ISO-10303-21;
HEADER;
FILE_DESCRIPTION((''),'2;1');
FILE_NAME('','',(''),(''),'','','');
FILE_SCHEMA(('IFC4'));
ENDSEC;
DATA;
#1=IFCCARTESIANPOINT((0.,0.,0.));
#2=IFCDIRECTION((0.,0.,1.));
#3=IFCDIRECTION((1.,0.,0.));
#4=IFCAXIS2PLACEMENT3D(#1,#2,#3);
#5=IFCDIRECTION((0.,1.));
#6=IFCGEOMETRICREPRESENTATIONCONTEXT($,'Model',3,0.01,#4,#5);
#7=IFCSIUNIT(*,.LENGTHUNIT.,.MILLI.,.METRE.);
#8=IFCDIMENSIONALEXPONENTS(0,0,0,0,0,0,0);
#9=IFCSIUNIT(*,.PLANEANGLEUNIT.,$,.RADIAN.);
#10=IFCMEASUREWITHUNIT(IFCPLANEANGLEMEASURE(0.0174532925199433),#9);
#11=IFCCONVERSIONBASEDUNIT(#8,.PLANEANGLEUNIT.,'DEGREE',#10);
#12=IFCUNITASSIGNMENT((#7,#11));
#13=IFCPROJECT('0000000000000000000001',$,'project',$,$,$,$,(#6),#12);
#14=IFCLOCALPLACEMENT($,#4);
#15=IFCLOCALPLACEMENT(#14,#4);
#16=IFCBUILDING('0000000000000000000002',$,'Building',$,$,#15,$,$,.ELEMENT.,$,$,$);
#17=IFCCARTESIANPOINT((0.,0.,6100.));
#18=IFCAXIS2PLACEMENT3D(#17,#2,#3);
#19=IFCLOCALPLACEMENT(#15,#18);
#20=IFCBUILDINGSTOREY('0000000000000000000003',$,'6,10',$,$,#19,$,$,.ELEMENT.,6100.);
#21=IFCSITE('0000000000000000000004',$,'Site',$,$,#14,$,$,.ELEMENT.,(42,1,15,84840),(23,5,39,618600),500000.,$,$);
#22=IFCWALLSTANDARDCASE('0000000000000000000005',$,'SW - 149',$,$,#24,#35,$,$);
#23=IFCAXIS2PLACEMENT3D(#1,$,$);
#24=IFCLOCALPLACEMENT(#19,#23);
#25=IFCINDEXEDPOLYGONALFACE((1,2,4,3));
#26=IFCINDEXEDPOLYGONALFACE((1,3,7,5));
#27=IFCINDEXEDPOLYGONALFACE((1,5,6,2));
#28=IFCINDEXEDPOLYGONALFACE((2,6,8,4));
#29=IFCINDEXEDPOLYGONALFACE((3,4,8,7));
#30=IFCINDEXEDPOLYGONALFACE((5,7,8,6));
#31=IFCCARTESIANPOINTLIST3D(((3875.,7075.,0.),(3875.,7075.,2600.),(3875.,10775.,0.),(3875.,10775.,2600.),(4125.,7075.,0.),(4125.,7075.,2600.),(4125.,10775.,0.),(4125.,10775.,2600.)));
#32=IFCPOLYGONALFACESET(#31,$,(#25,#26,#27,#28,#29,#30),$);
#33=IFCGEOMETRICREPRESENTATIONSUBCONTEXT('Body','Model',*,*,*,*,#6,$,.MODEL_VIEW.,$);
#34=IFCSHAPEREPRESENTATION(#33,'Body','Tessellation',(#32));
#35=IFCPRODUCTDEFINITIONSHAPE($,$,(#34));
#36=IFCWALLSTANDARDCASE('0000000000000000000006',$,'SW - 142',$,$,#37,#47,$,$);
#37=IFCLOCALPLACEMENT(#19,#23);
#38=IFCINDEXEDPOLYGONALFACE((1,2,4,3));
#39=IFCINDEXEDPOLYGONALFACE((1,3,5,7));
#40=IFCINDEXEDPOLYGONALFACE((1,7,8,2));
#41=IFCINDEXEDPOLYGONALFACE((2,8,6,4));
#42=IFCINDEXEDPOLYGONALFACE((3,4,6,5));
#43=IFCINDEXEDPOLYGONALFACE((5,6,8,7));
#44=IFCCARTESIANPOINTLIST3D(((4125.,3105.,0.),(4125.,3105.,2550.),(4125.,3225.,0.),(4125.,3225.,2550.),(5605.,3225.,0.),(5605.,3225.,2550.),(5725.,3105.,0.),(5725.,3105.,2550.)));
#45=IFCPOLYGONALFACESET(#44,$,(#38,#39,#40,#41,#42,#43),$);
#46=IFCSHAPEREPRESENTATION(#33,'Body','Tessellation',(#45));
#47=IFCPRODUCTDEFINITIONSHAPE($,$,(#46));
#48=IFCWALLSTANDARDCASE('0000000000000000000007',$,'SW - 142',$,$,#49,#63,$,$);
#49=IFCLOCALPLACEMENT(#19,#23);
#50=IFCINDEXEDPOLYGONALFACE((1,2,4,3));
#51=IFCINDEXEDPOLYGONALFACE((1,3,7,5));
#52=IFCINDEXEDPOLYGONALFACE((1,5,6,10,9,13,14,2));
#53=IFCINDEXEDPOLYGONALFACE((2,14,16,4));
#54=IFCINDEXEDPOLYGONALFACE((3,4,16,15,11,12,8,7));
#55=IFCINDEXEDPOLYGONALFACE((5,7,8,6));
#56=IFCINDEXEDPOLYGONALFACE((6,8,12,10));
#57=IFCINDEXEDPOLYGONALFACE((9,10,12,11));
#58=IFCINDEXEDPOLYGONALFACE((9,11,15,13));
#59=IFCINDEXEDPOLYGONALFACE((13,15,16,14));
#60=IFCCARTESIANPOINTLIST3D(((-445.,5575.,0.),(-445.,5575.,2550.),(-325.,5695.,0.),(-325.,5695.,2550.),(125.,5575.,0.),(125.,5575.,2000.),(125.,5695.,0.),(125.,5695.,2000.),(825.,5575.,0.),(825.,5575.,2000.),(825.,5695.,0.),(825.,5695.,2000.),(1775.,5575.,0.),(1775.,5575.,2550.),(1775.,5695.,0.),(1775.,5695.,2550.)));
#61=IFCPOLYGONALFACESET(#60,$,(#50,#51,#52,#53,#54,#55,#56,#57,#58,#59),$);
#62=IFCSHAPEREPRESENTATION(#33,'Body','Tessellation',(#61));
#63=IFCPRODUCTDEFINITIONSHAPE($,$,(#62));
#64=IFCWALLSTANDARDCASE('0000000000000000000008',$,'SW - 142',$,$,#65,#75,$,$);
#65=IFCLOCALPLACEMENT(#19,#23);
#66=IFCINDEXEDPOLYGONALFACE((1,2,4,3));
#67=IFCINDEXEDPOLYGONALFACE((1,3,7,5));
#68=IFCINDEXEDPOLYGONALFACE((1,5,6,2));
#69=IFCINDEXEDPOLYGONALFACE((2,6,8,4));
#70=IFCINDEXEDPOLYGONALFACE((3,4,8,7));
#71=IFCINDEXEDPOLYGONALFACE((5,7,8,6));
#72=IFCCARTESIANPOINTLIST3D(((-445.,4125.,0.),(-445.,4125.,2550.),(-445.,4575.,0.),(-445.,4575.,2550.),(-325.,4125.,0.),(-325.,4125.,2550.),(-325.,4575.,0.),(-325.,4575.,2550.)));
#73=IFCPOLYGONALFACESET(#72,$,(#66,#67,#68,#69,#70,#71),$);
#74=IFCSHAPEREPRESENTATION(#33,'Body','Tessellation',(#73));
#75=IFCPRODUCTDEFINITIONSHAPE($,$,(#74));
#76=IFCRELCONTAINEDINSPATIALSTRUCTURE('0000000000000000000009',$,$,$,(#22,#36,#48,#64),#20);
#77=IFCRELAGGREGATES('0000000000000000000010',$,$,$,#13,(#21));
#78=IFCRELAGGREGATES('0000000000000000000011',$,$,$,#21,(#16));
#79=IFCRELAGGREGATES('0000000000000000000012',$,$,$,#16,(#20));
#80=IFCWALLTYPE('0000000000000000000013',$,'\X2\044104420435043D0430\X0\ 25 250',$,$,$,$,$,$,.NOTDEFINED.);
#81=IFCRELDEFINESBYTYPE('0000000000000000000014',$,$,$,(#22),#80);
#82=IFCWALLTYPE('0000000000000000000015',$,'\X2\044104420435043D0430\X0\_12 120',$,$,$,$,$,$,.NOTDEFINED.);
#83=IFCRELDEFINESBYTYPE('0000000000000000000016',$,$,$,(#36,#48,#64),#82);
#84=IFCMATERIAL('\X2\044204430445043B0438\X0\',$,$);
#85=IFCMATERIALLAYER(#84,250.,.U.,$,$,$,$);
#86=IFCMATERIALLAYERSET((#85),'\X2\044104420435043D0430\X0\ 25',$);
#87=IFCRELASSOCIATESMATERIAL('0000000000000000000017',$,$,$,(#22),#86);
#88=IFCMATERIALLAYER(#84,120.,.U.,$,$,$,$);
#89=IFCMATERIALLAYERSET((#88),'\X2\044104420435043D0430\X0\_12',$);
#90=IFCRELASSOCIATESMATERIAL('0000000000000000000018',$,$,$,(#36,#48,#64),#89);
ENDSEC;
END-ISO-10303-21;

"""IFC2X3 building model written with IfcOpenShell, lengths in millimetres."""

from ifc_helpers import new_model, entity, si_unit, converted_unit, direction, frame, origin_with_axes, origin_2d_with_axis, place, context, subcontext, project, spatial, polyline, rectangle, outline, extrude, material, layer, layer_set, layer_usage, type_object, element, save


model = new_model("IFC2X3")

# Units and contexts
model_context = context("Model", 3, precision=0.01, world=origin_with_axes(), true_north=direction((0.0, 1.0)))
body_context = subcontext(model_context, "Body", "Model", "MODEL_VIEW")
ifc_project = project(units=[si_unit("LENGTHUNIT", "METRE", prefix="MILLI"), converted_unit("PLANEANGLEUNIT", "DEGREE", entity("IfcPlaneAngleMeasure", 0.0174532925199433), si_unit("PLANEANGLEUNIT", "RADIAN"), dimensions=[0, 0, 0, 0, 0, 0, 0])], contexts=[model_context])

# Site, building, storey
site_placement = place(None, origin_with_axes())
site = spatial("IfcSite", under=ifc_project, at=site_placement, Name="Site", CompositionType="ELEMENT", RefLatitude=(42, 1, 15, 84840), RefLongitude=(23, 5, 39, 618600), RefElevation=500000.0)
building_placement = place(site_placement, origin_with_axes())
building = spatial("IfcBuilding", under=site, at=building_placement, Name="Building", CompositionType="ELEMENT")
storey_placement = place(building_placement, frame((0.0, 0.0, 6100.0), z_axis=(0.0, 0.0, 1.0), x_axis=(1.0, 0.0, 0.0)))
storey = spatial("IfcBuildingStorey", under=building, at=storey_placement, Name="6,10", CompositionType="ELEMENT", Elevation=6100.0)

# Shared definitions
ifc_material_1 = material(Name="тухли")

# Wall
ifc_layer_1 = layer(ifc_material_1, 250.0, ventilated="UNKNOWN")
ifc_layer_set_1 = layer_set([ifc_layer_1], Name="стена 25")
wall_type_1 = type_object("IfcWallType", Name="стена 25 250", PredefinedType="NOTDEFINED")
ifc_layer_usage_1 = layer_usage(ifc_layer_set_1, "AXIS2", "NEGATIVE", 0.0)
wall_1_placement = place(storey_placement, frame((3875.0, 7075.0, 0.0), z_axis=(0.0, 0.0, 1.0), x_axis=(0.0, 1.0, 0.0)))
element("IfcWallStandardCase", 1, at=wall_1_placement, inside=storey, type_object=wall_type_1, material=ifc_layer_usage_1, Name="SW - 149", context=body_context, shape_type="SweptSolid", body=[
    extrude(outline(polyline([(0.0, -250.0), (3700.0, -250.0), (3700.0, 0.0), (0.0, 0.0), (0.0, -250.0)])), origin_with_axes(), (0.0, 0.0, 1.0), 2600.0),
])

# Wall
ifc_layer_2 = layer(ifc_material_1, 120.0, ventilated="UNKNOWN")
ifc_layer_set_2 = layer_set([ifc_layer_2], Name="стена_12")
ifc_layer_usage_2 = layer_usage(ifc_layer_set_2, "AXIS2", "NEGATIVE", 60.0)
wall_type_2 = type_object("IfcWallType", Name="стена_12 120", PredefinedType="NOTDEFINED")
wall_2_placement = place(storey_placement, frame((4125.0, 3165.0, 0.0), z_axis=(0.0, 0.0, 1.0), x_axis=(1.0, 0.0, 0.0)))
element("IfcWallStandardCase", 2, at=wall_2_placement, inside=storey, type_object=wall_type_2, material=ifc_layer_usage_2, Name="SW - 142", context=body_context, shape_type="SweptSolid", body=[
    extrude(outline(polyline([(0.0, -60.0), (1600.0, -60.0), (1480.0, 60.0), (0.0, 60.0), (0.0, -60.0)])), origin_with_axes(), (0.0, 0.0, 1.0), 2550.0),
])

# Wall, opening
ifc_layer_usage_3 = layer_usage(ifc_layer_set_2, "AXIS2", "NEGATIVE", 60.0)
wall_3_placement = place(storey_placement, frame((1775.0, 5635.0, 0.0), z_axis=(0.0, 0.0, 1.0), x_axis=(-1.0, 0.0, 0.0)))
wall_3 = element("IfcWallStandardCase", 3, at=wall_3_placement, inside=storey, type_object=wall_type_2, material=ifc_layer_usage_3, Name="SW - 142", context=body_context, shape_type="SweptSolid", body=[
    extrude(outline(polyline([(0.0, -60.0), (2100.0, -60.0), (2220.0, 60.0), (0.0, 60.0), (0.0, -60.0)])), origin_with_axes(), (0.0, 0.0, 1.0), 2550.0),
])
opening_1_placement = place(wall_3_placement, frame((1300.0, 0.0, 0.0), z_axis=(0.0, 0.0, 1.0), x_axis=(1.0, 0.0, 0.0)))
element("IfcOpeningElement", 4, at=opening_1_placement, cuts=wall_3, context=body_context, shape_type="SweptSolid", body=[
    extrude(rectangle(XDim=700.0, YDim=2000.0, at=origin_2d_with_axis()), frame((0.0, 120.0, 1000.0), z_axis=(0.0, -1.0, 0.0), x_axis=(-1.0, 0.0, 0.0)), (0.0, 0.0, 1.0), 360.0),
])

# Wall
ifc_layer_usage_4 = layer_usage(ifc_layer_set_2, "AXIS2", "NEGATIVE", 60.0)
wall_4_placement = place(storey_placement, frame((-385.0, 4575.0, 0.0), z_axis=(0.0, 0.0, 1.0), x_axis=(0.0, -1.0, 0.0)))
element("IfcWallStandardCase", 5, at=wall_4_placement, inside=storey, type_object=wall_type_2, material=ifc_layer_usage_4, Name="SW - 142", context=body_context, shape_type="SweptSolid", body=[
    extrude(outline(polyline([(0.0, -60.0), (450.0, -60.0), (450.0, 60.0), (0.0, 60.0), (0.0, -60.0)])), origin_with_axes(), (0.0, 0.0, 1.0), 2550.0),
])

save(model, "model.ifc")
